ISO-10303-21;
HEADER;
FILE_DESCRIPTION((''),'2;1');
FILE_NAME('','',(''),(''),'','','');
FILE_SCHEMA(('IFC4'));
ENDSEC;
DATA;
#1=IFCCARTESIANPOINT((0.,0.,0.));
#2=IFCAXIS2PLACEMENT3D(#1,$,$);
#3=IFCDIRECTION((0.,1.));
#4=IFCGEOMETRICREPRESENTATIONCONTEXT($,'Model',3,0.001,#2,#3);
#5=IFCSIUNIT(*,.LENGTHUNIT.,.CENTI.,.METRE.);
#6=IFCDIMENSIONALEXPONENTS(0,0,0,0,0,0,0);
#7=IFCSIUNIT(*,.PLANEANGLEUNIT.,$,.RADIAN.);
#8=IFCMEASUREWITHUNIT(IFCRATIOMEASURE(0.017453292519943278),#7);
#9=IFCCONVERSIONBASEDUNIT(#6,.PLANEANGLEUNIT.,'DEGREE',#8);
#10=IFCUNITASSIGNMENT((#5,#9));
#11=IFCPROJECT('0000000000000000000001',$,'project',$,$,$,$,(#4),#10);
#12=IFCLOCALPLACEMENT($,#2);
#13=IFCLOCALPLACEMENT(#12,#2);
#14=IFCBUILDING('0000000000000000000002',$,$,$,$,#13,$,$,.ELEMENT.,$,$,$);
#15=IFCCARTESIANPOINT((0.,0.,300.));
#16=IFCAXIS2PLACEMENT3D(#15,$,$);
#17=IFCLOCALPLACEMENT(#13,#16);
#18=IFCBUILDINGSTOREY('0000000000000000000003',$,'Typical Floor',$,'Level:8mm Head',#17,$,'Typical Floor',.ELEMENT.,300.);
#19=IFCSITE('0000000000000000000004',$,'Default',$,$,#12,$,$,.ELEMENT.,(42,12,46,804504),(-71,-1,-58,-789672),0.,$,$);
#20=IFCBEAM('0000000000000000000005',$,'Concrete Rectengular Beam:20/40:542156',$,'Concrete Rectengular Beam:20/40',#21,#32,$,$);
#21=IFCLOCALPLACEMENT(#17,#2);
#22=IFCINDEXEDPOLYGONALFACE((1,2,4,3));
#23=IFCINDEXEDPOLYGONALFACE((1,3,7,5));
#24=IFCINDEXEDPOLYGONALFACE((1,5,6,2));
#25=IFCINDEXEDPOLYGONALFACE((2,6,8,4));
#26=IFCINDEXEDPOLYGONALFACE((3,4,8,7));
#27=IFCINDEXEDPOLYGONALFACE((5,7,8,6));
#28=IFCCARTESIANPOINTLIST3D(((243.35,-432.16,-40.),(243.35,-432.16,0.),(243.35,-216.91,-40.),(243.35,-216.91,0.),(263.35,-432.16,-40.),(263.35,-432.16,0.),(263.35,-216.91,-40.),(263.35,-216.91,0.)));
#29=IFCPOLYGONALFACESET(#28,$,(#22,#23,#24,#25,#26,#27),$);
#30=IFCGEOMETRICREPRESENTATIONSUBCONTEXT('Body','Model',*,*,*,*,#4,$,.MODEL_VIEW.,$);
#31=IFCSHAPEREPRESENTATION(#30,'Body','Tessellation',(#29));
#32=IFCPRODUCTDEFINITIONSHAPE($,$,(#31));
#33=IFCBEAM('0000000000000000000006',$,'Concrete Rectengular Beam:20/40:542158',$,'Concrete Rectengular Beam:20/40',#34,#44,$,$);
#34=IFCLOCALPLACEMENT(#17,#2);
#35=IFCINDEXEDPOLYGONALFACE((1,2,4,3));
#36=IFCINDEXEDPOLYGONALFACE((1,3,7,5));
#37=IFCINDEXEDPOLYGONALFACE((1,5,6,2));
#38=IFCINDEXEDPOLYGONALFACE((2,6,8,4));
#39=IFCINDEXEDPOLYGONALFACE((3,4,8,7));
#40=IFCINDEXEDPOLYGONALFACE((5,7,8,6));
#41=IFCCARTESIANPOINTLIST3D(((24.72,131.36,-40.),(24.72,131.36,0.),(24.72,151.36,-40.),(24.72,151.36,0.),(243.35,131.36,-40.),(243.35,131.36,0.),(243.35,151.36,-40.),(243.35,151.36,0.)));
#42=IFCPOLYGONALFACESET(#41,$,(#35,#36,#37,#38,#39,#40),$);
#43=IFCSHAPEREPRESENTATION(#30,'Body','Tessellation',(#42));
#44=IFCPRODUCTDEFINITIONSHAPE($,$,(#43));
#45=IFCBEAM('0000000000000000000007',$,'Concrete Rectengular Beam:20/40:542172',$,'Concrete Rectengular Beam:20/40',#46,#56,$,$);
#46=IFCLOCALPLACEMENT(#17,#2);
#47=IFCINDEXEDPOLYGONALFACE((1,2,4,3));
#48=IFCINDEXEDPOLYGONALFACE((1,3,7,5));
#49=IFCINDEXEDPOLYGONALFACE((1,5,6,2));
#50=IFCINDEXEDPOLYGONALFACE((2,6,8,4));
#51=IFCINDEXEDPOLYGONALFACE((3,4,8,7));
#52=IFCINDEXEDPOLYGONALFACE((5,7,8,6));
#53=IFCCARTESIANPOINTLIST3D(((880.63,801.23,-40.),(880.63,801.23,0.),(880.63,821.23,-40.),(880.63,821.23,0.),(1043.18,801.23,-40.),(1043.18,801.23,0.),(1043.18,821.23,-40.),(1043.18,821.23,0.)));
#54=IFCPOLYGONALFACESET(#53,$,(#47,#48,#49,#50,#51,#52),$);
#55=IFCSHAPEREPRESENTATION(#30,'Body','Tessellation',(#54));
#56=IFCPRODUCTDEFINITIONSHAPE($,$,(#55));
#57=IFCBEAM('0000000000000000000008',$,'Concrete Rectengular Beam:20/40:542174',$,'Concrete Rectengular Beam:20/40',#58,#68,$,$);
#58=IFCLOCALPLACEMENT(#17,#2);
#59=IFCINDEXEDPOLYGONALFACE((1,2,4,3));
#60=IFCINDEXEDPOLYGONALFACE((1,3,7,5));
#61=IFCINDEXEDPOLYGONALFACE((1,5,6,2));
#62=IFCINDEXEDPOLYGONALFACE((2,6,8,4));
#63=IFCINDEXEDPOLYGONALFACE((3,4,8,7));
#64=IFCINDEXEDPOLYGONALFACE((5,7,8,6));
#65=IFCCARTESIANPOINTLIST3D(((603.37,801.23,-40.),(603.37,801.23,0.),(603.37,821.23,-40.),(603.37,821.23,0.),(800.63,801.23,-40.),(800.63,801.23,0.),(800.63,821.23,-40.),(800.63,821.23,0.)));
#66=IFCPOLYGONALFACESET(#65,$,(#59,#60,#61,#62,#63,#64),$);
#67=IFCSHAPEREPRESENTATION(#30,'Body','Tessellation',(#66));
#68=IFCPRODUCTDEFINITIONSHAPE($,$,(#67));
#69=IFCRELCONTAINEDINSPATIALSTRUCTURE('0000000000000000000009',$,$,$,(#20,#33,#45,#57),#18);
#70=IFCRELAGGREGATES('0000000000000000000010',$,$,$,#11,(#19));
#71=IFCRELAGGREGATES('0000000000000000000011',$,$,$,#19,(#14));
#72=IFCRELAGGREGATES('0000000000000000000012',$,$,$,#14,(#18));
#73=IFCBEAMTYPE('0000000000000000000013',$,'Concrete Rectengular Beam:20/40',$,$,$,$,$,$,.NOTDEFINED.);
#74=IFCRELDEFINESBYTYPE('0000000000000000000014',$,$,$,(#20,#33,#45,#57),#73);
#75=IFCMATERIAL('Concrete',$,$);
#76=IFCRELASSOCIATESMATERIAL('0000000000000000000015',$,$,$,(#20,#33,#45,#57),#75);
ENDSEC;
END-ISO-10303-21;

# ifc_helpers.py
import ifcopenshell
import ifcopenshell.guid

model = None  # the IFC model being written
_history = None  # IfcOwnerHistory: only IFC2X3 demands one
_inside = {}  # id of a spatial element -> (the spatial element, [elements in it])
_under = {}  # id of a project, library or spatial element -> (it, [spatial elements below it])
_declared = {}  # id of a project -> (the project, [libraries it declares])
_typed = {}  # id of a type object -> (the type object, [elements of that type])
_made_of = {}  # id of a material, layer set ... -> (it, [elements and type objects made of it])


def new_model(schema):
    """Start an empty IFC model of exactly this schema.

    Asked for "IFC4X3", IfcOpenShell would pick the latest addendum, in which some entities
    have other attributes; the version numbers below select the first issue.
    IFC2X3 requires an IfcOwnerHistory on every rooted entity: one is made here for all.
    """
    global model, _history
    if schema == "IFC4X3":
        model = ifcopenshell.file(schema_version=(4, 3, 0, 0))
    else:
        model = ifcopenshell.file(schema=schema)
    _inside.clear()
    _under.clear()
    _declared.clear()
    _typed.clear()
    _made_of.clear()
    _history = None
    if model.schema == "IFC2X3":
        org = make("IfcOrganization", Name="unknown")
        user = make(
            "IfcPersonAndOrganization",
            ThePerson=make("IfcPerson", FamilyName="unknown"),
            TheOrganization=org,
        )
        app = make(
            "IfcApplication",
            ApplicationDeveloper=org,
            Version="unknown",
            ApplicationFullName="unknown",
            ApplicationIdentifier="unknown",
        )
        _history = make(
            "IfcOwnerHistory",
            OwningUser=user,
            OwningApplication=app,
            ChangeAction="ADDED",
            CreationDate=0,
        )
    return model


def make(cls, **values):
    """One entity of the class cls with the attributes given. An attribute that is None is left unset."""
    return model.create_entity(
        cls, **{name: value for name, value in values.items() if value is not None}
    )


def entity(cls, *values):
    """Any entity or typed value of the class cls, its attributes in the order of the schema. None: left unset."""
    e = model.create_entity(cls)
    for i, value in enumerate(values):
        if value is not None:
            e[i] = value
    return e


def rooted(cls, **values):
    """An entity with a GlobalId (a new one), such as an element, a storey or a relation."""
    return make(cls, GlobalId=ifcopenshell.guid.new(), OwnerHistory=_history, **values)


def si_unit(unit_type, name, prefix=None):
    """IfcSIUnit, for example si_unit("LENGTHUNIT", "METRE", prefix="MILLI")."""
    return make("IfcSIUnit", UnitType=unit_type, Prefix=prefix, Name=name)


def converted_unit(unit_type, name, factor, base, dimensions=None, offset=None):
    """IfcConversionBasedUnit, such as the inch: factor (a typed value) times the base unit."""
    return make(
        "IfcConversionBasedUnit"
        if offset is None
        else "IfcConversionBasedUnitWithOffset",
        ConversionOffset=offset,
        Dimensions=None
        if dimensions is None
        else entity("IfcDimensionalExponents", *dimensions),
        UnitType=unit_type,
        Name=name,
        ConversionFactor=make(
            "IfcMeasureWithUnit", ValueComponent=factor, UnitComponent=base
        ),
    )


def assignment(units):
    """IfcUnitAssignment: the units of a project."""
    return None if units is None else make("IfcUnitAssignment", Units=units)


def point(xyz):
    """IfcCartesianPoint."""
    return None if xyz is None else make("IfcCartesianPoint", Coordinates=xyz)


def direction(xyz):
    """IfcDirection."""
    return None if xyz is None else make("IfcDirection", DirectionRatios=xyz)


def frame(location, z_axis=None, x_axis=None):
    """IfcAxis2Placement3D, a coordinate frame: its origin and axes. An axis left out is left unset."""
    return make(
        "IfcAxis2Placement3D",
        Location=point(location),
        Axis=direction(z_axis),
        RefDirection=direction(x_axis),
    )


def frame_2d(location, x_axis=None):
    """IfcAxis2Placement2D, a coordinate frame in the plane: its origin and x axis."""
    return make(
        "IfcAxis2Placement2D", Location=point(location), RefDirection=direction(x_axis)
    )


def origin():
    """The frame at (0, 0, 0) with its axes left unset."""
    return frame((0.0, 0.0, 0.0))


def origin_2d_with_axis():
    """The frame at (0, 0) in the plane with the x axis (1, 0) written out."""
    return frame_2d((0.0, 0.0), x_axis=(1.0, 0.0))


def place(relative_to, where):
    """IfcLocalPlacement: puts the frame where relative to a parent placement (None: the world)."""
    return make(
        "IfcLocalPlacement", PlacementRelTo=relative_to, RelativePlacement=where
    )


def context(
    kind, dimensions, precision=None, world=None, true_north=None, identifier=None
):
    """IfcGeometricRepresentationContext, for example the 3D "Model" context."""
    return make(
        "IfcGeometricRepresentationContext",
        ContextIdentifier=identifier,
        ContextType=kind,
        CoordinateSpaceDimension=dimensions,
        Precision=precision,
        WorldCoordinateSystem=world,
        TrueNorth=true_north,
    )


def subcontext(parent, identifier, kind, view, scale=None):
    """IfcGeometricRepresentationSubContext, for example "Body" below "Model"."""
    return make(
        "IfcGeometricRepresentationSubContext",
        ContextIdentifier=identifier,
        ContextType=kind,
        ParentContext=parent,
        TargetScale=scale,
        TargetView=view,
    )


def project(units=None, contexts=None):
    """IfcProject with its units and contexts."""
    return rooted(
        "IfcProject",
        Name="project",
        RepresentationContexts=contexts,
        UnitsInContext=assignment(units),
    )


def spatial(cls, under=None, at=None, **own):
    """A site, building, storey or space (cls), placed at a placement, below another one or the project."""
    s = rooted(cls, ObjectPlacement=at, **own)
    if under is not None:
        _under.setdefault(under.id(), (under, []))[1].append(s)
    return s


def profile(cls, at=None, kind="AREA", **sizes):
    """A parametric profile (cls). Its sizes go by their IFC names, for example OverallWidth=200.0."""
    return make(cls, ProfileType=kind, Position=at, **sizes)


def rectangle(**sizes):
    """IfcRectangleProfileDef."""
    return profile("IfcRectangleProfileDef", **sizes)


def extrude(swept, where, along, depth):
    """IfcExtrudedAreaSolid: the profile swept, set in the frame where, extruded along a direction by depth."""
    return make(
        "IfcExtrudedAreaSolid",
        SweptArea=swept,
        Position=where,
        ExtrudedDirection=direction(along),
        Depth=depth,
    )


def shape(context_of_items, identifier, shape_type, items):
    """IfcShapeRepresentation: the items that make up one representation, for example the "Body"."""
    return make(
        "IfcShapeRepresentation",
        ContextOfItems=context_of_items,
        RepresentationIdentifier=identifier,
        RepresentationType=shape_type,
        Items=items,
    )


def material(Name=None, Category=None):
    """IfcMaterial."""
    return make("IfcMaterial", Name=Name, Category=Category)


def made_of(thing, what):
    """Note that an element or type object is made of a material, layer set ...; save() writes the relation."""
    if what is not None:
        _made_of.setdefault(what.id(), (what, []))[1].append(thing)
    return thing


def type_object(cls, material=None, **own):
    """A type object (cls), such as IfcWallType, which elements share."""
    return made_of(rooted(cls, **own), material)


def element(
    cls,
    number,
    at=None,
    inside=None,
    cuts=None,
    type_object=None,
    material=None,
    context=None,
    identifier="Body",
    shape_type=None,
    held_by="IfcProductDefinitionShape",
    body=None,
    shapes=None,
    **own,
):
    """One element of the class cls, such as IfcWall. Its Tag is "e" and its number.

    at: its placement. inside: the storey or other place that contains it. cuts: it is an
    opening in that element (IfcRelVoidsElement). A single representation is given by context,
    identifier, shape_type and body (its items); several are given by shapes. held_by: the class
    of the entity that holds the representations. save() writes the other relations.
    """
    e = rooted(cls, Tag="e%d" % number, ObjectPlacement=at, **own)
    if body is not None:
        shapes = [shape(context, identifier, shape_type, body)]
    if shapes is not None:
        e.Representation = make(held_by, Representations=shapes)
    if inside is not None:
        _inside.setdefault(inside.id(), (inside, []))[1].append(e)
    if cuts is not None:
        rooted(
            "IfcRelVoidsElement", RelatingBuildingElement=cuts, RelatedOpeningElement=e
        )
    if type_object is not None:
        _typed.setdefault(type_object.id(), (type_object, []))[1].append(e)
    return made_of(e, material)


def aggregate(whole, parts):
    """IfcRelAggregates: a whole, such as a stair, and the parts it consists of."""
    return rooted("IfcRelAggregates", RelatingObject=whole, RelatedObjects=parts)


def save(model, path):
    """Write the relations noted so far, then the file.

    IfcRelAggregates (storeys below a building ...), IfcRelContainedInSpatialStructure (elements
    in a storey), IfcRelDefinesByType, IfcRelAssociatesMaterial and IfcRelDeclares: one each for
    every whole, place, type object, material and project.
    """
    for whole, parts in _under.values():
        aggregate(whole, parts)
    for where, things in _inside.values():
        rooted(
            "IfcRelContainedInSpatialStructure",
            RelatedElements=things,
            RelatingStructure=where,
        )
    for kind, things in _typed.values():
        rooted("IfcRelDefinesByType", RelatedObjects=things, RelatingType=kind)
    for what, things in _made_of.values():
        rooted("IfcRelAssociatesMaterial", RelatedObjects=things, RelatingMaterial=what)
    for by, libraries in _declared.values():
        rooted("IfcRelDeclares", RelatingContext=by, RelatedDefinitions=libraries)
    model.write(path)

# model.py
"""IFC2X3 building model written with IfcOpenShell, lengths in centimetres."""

from ifc_helpers import new_model, entity, si_unit, converted_unit, direction, frame, frame_2d, origin, origin_2d_with_axis, place, context, subcontext, project, spatial, rectangle, extrude, material, type_object, element, save


model = new_model("IFC2X3")

# Units and contexts
model_context = context("Model", 3, precision=0.001, world=origin(), true_north=direction((0.0, 1.0)))
body_context = subcontext(model_context, "Body", "Model", "MODEL_VIEW")
ifc_project = project(units=[si_unit("LENGTHUNIT", "METRE", prefix="CENTI"), converted_unit("PLANEANGLEUNIT", "DEGREE", entity("IfcRatioMeasure", 0.017453292519943278), si_unit("PLANEANGLEUNIT", "RADIAN"), dimensions=[0, 0, 0, 0, 0, 0, 0])], contexts=[model_context])

# Site, building, storey
site_placement = place(None, origin())
site = spatial("IfcSite", under=ifc_project, at=site_placement, Name="Default", CompositionType="ELEMENT", RefLatitude=(42, 12, 46, 804504), RefLongitude=(-71, -1, -58, -789672), RefElevation=0.0)
building_placement = place(site_placement, origin())
building = spatial("IfcBuilding", under=site, at=building_placement, CompositionType="ELEMENT")
storey_placement = place(building_placement, frame((0.0, 0.0, 300.0)))
storey = spatial("IfcBuildingStorey", under=building, at=storey_placement, Name="Typical Floor", ObjectType="Level:8mm Head", LongName="Typical Floor", CompositionType="ELEMENT", Elevation=300.0)

# Beams
ifc_material = material(Name="Concrete")
beam_type_1 = type_object("IfcBeamType", Name="Concrete Rectengular Beam:20/40", PredefinedType="NOTDEFINED")
beam_1_placement = place(storey_placement, frame((253.35, -472.16, 0.0), z_axis=(0.0, 0.0, 1.0), x_axis=(0.0, 1.0, 0.0)))
element("IfcBeam", 1, at=beam_1_placement, inside=storey, type_object=beam_type_1, material=ifc_material, Name="Concrete Rectengular Beam:20/40:542156", ObjectType="Concrete Rectengular Beam:20/40", context=body_context, shape_type="SweptSolid", body=[
    extrude(rectangle(XDim=40.0, YDim=20.0, at=origin_2d_with_axis()), frame((40.0, 0.0, -20.0), z_axis=(1.0, 0.0, 0.0), x_axis=(0.0, 0.0, -1.0)), (0.0, 0.0, 1.0), 215.25),
])
beam_2_placement = place(storey_placement, frame((253.35, 141.36, 0.0), z_axis=(0.0, 0.0, 1.0), x_axis=(-1.0, 0.0, 0.0)))
element("IfcBeam", 2, at=beam_2_placement, inside=storey, type_object=beam_type_1, material=ifc_material, Name="Concrete Rectengular Beam:20/40:542158", ObjectType="Concrete Rectengular Beam:20/40", context=body_context, shape_type="SweptSolid", body=[
    extrude(rectangle(XDim=40.0, YDim=20.0, at=frame_2d((0.0, 0.0), x_axis=(1.0, 0.0))), frame((10.0, 0.0, -20.0), z_axis=(1.0, 0.0, 0.0), x_axis=(0.0, 0.0, -1.0)), (0.0, 0.0, 1.0), 218.63),
])
beam_3_placement = place(storey_placement, frame((1083.18, 811.23, 0.0), z_axis=(0.0, 0.0, 1.0), x_axis=(-1.0, 0.0, 0.0)))
element("IfcBeam", 3, at=beam_3_placement, inside=storey, type_object=beam_type_1, material=ifc_material, Name="Concrete Rectengular Beam:20/40:542172", ObjectType="Concrete Rectengular Beam:20/40", context=body_context, shape_type="SweptSolid", body=[
    extrude(rectangle(XDim=40.0, YDim=20.0, at=frame_2d((0.0, 0.0), x_axis=(1.0, 0.0))), frame((40.0, 0.0, -20.0), z_axis=(1.0, 0.0, 0.0), x_axis=(0.0, 0.0, -1.0)), (0.0, 0.0, 1.0), 162.55),
])
beam_4_placement = place(storey_placement, frame((840.63, 811.23, 0.0), z_axis=(0.0, 0.0, 1.0), x_axis=(-1.0, 0.0, 0.0)))
element("IfcBeam", 4, at=beam_4_placement, inside=storey, type_object=beam_type_1, material=ifc_material, Name="Concrete Rectengular Beam:20/40:542174", ObjectType="Concrete Rectengular Beam:20/40", context=body_context, shape_type="SweptSolid", body=[
    extrude(rectangle(XDim=40.0, YDim=20.0, at=frame_2d((0.0, 0.0), x_axis=(1.0, 0.0))), frame((40.0, 0.0, -20.0), z_axis=(1.0, 0.0, 0.0), x_axis=(0.0, 0.0, -1.0)), (0.0, 0.0, 1.0), 197.26),
])

save(model, "model.ifc")
